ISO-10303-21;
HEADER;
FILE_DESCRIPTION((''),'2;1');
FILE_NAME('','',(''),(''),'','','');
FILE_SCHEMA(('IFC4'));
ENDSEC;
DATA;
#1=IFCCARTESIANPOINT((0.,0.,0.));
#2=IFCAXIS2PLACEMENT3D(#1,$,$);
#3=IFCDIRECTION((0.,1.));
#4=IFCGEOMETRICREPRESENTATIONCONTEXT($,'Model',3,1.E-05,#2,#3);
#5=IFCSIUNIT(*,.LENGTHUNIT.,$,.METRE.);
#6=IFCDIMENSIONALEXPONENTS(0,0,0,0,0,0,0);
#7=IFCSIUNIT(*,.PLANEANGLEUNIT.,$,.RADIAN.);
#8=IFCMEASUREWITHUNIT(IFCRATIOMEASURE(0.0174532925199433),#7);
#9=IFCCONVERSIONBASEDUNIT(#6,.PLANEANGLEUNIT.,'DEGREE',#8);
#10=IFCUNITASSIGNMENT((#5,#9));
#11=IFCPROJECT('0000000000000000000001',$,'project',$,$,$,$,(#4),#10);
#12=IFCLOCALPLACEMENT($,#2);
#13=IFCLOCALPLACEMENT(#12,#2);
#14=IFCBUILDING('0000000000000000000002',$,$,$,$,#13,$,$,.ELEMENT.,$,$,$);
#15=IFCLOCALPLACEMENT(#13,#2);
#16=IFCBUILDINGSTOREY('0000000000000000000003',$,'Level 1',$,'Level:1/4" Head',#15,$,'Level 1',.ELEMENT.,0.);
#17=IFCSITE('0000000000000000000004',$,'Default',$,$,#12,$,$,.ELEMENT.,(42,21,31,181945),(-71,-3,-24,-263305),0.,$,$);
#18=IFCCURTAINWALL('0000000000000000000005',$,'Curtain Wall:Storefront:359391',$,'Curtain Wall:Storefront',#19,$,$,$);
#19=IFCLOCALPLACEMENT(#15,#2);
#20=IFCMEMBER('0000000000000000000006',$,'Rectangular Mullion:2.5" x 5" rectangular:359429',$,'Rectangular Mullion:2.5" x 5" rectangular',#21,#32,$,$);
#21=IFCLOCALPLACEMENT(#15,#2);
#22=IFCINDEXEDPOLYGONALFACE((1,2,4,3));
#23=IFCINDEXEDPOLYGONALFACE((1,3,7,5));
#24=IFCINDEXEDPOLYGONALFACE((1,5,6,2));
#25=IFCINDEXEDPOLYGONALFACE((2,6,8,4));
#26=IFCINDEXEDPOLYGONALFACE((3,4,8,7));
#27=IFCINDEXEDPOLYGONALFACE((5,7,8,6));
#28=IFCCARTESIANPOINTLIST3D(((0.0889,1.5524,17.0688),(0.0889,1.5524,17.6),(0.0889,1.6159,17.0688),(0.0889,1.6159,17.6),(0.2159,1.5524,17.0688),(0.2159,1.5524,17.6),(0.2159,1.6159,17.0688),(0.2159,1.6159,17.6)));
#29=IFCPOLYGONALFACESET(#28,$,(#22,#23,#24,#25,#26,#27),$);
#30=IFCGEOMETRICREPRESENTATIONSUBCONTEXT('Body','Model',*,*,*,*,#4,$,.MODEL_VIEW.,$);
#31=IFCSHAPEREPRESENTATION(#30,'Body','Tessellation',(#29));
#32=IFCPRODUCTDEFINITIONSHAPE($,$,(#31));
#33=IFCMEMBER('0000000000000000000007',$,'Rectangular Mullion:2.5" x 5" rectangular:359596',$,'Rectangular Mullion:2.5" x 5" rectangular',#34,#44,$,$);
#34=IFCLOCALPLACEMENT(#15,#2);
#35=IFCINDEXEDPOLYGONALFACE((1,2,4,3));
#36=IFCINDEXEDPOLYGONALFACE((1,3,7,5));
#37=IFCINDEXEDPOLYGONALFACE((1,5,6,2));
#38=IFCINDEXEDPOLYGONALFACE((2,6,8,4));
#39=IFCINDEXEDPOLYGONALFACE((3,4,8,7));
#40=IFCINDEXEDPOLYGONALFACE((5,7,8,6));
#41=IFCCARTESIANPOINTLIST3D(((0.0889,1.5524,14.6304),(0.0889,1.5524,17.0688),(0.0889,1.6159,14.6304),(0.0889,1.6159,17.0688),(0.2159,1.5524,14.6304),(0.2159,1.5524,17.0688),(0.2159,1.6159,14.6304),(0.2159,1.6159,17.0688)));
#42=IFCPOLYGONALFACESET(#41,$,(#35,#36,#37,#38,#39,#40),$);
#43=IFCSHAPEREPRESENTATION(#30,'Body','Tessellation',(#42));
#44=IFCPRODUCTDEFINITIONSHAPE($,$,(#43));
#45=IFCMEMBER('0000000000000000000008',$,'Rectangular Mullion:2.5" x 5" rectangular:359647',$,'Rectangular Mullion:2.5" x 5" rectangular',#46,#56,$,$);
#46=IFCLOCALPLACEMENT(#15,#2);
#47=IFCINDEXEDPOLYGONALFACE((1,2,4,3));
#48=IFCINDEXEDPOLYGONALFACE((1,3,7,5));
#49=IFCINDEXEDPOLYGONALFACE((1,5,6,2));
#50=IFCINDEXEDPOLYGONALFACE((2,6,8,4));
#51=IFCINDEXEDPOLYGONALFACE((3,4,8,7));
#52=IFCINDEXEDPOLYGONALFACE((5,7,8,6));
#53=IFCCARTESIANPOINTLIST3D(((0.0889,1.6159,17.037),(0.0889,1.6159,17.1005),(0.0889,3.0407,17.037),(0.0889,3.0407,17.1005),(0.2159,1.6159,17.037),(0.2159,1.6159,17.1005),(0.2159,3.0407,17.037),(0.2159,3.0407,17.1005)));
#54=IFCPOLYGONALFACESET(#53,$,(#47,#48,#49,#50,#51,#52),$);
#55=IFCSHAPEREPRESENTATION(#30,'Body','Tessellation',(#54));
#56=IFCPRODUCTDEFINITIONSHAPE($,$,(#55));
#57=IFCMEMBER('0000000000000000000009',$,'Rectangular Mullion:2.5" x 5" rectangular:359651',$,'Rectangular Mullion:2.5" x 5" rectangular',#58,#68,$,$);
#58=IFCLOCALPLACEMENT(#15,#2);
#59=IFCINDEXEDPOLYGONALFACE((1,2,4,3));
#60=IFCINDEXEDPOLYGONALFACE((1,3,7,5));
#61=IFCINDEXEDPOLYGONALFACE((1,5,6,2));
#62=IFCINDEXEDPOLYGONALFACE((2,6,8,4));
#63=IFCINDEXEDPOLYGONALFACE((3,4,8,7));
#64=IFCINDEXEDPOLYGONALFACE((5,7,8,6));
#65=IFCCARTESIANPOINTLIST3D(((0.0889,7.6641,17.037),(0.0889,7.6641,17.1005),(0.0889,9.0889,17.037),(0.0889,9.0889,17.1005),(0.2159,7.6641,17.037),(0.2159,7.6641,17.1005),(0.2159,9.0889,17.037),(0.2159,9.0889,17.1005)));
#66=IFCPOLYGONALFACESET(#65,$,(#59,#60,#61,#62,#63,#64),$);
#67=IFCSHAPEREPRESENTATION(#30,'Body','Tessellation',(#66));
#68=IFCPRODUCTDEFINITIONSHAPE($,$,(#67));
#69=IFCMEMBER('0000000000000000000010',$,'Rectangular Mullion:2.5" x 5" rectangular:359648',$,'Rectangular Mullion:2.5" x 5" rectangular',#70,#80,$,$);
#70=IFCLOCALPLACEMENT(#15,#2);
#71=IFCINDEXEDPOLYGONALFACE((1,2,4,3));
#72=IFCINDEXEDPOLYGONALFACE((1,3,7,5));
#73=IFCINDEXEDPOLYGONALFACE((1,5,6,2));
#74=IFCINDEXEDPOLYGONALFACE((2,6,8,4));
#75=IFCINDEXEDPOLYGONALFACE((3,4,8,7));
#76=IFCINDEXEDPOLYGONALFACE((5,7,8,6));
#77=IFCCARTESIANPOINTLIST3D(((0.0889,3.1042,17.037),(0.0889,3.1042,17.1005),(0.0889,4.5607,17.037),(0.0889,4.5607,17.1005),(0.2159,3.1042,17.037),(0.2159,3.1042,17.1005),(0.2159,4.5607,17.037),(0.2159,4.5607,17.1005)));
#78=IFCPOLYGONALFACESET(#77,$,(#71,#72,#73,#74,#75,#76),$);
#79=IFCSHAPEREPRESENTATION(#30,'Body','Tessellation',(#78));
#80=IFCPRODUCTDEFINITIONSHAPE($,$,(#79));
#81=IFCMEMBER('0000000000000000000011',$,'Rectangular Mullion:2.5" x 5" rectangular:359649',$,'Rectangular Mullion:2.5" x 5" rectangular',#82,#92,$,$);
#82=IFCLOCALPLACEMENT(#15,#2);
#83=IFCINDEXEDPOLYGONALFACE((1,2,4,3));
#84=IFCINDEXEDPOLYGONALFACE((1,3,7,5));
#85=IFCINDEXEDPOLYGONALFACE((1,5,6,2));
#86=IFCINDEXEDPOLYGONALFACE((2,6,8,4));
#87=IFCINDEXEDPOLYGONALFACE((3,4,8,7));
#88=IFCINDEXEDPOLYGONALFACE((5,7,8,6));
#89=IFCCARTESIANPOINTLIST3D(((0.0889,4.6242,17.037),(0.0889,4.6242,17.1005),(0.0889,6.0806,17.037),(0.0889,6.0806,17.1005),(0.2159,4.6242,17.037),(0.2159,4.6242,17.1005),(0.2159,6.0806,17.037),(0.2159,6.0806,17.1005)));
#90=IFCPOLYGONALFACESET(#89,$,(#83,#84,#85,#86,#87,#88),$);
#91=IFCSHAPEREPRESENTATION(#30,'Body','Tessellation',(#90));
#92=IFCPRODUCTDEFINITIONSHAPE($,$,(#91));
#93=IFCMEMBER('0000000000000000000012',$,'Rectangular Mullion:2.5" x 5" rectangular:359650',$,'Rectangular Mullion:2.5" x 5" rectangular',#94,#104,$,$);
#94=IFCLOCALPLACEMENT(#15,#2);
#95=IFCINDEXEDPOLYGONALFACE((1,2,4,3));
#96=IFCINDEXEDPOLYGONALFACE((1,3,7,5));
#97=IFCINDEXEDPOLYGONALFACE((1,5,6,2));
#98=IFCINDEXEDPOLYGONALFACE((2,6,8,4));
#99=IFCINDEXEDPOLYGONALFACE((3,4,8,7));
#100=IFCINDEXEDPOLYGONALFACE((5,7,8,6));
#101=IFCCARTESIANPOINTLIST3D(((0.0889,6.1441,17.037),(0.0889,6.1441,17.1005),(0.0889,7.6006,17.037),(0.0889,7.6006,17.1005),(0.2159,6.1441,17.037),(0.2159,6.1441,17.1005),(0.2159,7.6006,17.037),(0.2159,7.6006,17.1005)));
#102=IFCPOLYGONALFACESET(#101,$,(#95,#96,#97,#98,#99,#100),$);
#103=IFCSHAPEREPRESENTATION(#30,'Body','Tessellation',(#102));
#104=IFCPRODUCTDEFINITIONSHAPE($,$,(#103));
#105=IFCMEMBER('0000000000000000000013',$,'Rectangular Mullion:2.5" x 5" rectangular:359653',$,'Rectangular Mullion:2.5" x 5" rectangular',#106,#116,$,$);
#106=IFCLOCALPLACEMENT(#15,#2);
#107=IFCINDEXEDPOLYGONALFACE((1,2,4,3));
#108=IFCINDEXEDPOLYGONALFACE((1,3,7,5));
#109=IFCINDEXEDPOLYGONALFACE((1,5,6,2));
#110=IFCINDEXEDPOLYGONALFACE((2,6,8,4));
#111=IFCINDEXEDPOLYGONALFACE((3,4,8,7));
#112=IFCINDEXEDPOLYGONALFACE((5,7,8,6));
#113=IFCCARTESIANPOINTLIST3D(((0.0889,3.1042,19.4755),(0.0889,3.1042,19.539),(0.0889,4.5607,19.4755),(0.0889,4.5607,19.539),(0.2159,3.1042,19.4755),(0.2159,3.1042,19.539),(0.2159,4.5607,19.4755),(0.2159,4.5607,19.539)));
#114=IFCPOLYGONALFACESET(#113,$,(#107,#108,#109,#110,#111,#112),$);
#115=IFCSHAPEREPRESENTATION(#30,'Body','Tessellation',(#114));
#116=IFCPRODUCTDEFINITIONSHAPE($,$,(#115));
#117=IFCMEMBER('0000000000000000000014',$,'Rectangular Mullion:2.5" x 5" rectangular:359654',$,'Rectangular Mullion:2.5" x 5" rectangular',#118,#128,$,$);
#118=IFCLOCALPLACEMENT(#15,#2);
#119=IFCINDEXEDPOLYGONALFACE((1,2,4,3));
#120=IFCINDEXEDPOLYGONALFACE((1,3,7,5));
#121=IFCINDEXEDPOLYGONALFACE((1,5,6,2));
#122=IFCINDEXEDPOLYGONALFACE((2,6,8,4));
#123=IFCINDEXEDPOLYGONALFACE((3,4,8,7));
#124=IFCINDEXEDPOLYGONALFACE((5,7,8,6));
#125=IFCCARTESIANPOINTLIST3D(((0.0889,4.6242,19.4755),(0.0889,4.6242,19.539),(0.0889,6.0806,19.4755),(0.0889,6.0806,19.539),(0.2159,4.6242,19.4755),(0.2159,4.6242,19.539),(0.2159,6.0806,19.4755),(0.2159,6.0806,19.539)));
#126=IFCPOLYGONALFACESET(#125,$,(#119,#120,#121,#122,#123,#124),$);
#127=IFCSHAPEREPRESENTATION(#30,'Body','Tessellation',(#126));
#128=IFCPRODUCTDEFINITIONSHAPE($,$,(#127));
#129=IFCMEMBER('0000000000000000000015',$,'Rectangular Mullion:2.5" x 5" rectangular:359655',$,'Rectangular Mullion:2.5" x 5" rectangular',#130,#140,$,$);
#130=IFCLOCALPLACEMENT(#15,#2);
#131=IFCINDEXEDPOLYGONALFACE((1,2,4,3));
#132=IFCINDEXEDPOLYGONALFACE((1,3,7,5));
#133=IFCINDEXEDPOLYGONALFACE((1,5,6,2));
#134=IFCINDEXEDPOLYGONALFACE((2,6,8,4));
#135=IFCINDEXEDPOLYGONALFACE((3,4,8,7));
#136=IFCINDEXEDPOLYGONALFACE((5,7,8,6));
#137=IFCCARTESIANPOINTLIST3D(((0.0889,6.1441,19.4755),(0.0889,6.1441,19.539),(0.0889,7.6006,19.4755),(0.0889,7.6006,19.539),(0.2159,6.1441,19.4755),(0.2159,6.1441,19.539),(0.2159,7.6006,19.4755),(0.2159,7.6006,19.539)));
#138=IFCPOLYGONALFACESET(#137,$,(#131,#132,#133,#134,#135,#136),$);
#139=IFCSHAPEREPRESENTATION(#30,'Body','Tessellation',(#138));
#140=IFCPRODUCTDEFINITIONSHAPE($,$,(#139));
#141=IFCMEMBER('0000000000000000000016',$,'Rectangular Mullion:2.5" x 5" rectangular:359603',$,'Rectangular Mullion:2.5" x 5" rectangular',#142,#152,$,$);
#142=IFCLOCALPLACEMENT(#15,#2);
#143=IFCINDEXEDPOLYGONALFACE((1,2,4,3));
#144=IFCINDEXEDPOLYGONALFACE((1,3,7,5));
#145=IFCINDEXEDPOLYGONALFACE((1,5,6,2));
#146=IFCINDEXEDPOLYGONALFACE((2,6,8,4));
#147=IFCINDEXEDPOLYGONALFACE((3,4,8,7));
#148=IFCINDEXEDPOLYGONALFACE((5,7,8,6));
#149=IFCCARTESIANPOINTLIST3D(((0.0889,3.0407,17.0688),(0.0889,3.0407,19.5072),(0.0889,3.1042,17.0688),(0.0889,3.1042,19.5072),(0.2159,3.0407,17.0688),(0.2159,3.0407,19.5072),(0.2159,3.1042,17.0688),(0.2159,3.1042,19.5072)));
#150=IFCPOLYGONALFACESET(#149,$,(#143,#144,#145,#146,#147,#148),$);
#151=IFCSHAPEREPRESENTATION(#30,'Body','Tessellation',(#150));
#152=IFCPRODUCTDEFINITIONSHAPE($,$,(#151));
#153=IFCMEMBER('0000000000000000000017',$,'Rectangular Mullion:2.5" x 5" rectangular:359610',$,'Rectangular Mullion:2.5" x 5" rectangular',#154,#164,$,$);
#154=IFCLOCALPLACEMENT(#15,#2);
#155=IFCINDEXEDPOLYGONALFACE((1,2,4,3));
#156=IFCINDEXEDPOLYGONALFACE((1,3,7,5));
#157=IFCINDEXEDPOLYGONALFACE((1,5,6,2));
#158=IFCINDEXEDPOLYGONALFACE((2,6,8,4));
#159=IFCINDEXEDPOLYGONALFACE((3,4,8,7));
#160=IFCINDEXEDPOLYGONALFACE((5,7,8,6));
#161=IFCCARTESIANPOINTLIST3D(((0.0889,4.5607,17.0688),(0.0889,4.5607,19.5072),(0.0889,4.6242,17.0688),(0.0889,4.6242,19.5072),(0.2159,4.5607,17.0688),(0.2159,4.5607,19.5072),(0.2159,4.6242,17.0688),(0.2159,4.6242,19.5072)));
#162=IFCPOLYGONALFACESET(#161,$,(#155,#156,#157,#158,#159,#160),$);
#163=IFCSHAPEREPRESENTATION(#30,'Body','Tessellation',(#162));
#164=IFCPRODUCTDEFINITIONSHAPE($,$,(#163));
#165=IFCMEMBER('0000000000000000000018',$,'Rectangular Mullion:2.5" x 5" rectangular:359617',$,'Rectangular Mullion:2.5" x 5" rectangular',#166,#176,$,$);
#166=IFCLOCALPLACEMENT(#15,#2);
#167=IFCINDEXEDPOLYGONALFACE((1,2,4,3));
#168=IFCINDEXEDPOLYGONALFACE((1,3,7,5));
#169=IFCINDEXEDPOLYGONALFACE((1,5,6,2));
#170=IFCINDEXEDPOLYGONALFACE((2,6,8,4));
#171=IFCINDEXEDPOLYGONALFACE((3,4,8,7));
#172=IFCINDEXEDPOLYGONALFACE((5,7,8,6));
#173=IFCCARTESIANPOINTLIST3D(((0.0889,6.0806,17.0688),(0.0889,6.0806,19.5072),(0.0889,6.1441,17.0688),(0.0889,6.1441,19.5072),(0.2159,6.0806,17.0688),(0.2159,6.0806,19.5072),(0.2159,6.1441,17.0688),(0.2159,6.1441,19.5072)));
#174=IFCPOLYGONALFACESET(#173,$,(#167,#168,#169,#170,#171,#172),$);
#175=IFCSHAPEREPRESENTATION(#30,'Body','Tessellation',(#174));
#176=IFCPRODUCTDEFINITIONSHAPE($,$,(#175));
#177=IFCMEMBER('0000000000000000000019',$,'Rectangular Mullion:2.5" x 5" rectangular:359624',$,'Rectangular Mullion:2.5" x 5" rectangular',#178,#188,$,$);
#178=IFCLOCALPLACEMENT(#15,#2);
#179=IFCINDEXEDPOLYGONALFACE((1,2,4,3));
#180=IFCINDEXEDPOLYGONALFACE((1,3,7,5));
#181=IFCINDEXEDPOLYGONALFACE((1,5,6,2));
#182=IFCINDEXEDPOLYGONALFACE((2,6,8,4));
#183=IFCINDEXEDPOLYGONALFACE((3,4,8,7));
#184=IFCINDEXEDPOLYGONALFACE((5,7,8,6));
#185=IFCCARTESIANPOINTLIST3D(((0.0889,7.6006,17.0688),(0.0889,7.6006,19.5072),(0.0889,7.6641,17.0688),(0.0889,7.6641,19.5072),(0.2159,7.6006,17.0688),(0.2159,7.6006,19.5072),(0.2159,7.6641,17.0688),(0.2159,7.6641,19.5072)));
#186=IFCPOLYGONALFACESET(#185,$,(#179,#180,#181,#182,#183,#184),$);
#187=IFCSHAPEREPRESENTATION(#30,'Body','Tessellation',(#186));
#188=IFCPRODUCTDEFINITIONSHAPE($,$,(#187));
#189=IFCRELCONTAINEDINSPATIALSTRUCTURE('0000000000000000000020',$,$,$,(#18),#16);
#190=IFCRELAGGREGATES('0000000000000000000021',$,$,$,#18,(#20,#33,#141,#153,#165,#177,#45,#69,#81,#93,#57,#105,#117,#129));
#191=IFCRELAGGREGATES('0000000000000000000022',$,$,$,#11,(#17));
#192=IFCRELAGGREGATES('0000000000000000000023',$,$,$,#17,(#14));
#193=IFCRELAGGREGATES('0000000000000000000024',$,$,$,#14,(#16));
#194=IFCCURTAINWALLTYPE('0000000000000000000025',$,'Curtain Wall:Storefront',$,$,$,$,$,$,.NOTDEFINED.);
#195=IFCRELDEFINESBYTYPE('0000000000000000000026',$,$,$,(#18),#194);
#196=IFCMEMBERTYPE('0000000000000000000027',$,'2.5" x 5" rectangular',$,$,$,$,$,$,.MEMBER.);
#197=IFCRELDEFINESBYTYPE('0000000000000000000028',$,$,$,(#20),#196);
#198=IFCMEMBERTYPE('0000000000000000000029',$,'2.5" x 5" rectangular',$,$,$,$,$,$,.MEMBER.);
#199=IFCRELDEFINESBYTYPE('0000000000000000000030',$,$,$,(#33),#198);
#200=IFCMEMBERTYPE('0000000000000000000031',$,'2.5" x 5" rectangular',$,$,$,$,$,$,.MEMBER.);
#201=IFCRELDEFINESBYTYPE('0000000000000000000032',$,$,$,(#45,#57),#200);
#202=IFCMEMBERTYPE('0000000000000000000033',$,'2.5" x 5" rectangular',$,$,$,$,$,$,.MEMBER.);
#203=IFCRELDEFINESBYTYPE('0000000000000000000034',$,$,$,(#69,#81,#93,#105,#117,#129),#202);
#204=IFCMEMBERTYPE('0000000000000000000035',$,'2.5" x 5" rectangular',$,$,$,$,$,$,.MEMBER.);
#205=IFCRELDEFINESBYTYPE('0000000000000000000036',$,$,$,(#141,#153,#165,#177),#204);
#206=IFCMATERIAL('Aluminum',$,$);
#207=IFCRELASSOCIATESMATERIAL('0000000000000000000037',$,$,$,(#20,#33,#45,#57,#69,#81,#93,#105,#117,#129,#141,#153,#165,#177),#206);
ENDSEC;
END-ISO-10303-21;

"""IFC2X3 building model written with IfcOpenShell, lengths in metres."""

from ifc_helpers import new_model, entity, si_unit, converted_unit, direction, frame, origin, origin_2d_with_axis, place, context, subcontext, project, spatial, rectangle, extrude, source, transform, mapped, material, type_object, type_shapes, element, aggregate, save


model = new_model("IFC2X3")

# Units and contexts
model_context = context("Model", 3, precision=1e-05, world=origin(), true_north=direction((0.0, 1.0)))
body_context = subcontext(model_context, "Body", "Model", "MODEL_VIEW")
ifc_project = project(units=[si_unit("LENGTHUNIT", "METRE"), converted_unit("PLANEANGLEUNIT", "DEGREE", entity("IfcRatioMeasure", 0.0174532925199433), si_unit("PLANEANGLEUNIT", "RADIAN"), dimensions=[0, 0, 0, 0, 0, 0, 0])], contexts=[model_context])

# Site, building, storey
site_placement = place(None, origin())
site = spatial("IfcSite", under=ifc_project, at=site_placement, Name="Default", CompositionType="ELEMENT", RefLatitude=(42, 21, 31, 181945), RefLongitude=(-71, -3, -24, -263305), RefElevation=0.0)
building_placement = place(site_placement, origin())
building = spatial("IfcBuilding", under=site, at=building_placement, CompositionType="ELEMENT")
storey_placement = place(building_placement, origin())
storey = spatial("IfcBuildingStorey", under=building, at=storey_placement, Name="Level 1", ObjectType="Level:1/4\" Head", LongName="Level 1", CompositionType="ELEMENT", Elevation=0.0)

# Curtain wall, members
curtain_wall_type = type_object("IfcCurtainWallType", Name="Curtain Wall:Storefront", PredefinedType="NOTDEFINED")
curtain_wall_1_placement = place(storey_placement, origin())
curtain_wall_1 = element("IfcCurtainWall", 1, at=curtain_wall_1_placement, inside=storey, type_object=curtain_wall_type, Name="Curtain Wall:Storefront:359391", ObjectType="Curtain Wall:Storefront")
ifc_material_1 = material(Name="Aluminum")
member_type_1 = type_object("IfcMemberType", Name="2.5\" x 5\" rectangular", PredefinedType="MEMBER")
shared_shape_1 = source(origin(), body_context, "Body", "SweptSolid", [
    extrude(rectangle(XDim=0.127, YDim=0.0635, at=origin_2d_with_axis()), frame((-0.0318, 0.0, -0.5312), z_axis=(0.0, 0.0, 1.0), x_axis=(0.0, -1.0, 0.0)), (0.0, 0.0, 1.0), 0.5312),
])
type_shapes(member_type_1, [shared_shape_1])
member_1_placement = place(storey_placement, frame((0.1524, 1.5524, 17.6), z_axis=(0.0, 0.0, 1.0), x_axis=(0.0, -1.0, 0.0)))
member_1 = element("IfcMember", 2, at=member_1_placement, type_object=member_type_1, material=ifc_material_1, Name="Rectangular Mullion:2.5\" x 5\" rectangular:359429", ObjectType="Rectangular Mullion:2.5\" x 5\" rectangular", context=body_context, shape_type="MappedRepresentation", body=[
    mapped(shared_shape_1, transform((0.0, 0.0, 0.0), scale=1.0)),
])
member_type_2 = type_object("IfcMemberType", Name="2.5\" x 5\" rectangular", PredefinedType="MEMBER")
shared_shape_2 = source(origin(), body_context, "Body", "SweptSolid", [
    extrude(rectangle(XDim=0.127, YDim=0.0635, at=origin_2d_with_axis()), frame((-0.0318, 0.0, -2.4384), z_axis=(0.0, 0.0, 1.0), x_axis=(0.0, -1.0, 0.0)), (0.0, 0.0, 1.0), 2.4384),
])
type_shapes(member_type_2, [shared_shape_2])
member_2_placement = place(storey_placement, frame((0.1524, 1.5524, 17.0688), z_axis=(0.0, 0.0, 1.0), x_axis=(0.0, -1.0, 0.0)))
member_2 = element("IfcMember", 3, at=member_2_placement, type_object=member_type_2, material=ifc_material_1, Name="Rectangular Mullion:2.5\" x 5\" rectangular:359596", ObjectType="Rectangular Mullion:2.5\" x 5\" rectangular", context=body_context, shape_type="MappedRepresentation", body=[
    mapped(shared_shape_2, transform((0.0, 0.0, 0.0), scale=1.0)),
])
member_type_3 = type_object("IfcMemberType", Name="2.5\" x 5\" rectangular", PredefinedType="MEMBER")
shared_shape_3 = source(origin(), body_context, "Body", "SweptSolid", [
    extrude(rectangle(XDim=0.127, YDim=0.0635, at=origin_2d_with_axis()), frame((0.0, 0.0, -1.4248), z_axis=(0.0, 0.0, 1.0), x_axis=(0.0, -1.0, 0.0)), (0.0, 0.0, 1.0), 1.4248),
])
type_shapes(member_type_3, [shared_shape_3])
member_3_placement = place(storey_placement, frame((0.1524, 3.0407, 17.0688), z_axis=(0.0, 1.0, 0.0), x_axis=(0.0, 0.0, 1.0)))
member_3 = element("IfcMember", 4, at=member_3_placement, type_object=member_type_3, material=ifc_material_1, Name="Rectangular Mullion:2.5\" x 5\" rectangular:359647", ObjectType="Rectangular Mullion:2.5\" x 5\" rectangular", context=body_context, shape_type="MappedRepresentation", body=[
    mapped(shared_shape_3, transform((0.0, 0.0, 0.0), scale=1.0)),
])
member_4_placement = place(storey_placement, frame((0.1524, 9.0889, 17.0688), z_axis=(0.0, 1.0, 0.0), x_axis=(0.0, 0.0, 1.0)))
member_4 = element("IfcMember", 5, at=member_4_placement, type_object=member_type_3, material=ifc_material_1, Name="Rectangular Mullion:2.5\" x 5\" rectangular:359651", ObjectType="Rectangular Mullion:2.5\" x 5\" rectangular", context=body_context, shape_type="MappedRepresentation", body=[
    mapped(shared_shape_3, transform((0.0, 0.0, 0.0), scale=1.0)),
])
member_type_4 = type_object("IfcMemberType", Name="2.5\" x 5\" rectangular", PredefinedType="MEMBER")
shared_shape_4 = source(origin(), body_context, "Body", "SweptSolid", [
    extrude(rectangle(XDim=0.127, YDim=0.0635, at=origin_2d_with_axis()), frame((0.0, 0.0, -1.4565), z_axis=(0.0, 0.0, 1.0), x_axis=(0.0, -1.0, 0.0)), (0.0, 0.0, 1.0), 1.4565),
])
type_shapes(member_type_4, [shared_shape_4])
member_5_placement = place(storey_placement, frame((0.1524, 4.5607, 17.0688), z_axis=(0.0, 1.0, 0.0), x_axis=(0.0, 0.0, 1.0)))
member_5 = element("IfcMember", 6, at=member_5_placement, type_object=member_type_4, material=ifc_material_1, Name="Rectangular Mullion:2.5\" x 5\" rectangular:359648", ObjectType="Rectangular Mullion:2.5\" x 5\" rectangular", context=body_context, shape_type="MappedRepresentation", body=[
    mapped(shared_shape_4, transform((0.0, 0.0, 0.0), scale=1.0)),
])
member_6_placement = place(storey_placement, frame((0.1524, 6.0806, 17.0688), z_axis=(0.0, 1.0, 0.0), x_axis=(0.0, 0.0, 1.0)))
member_6 = element("IfcMember", 7, at=member_6_placement, type_object=member_type_4, material=ifc_material_1, Name="Rectangular Mullion:2.5\" x 5\" rectangular:359649", ObjectType="Rectangular Mullion:2.5\" x 5\" rectangular", context=body_context, shape_type="MappedRepresentation", body=[
    mapped(shared_shape_4, transform((0.0, 0.0, 0.0), scale=1.0)),
])
member_7_placement = place(storey_placement, frame((0.1524, 7.6006, 17.0688), z_axis=(0.0, 1.0, 0.0), x_axis=(0.0, 0.0, 1.0)))
member_7 = element("IfcMember", 8, at=member_7_placement, type_object=member_type_4, material=ifc_material_1, Name="Rectangular Mullion:2.5\" x 5\" rectangular:359650", ObjectType="Rectangular Mullion:2.5\" x 5\" rectangular", context=body_context, shape_type="MappedRepresentation", body=[
    mapped(shared_shape_4, transform((0.0, 0.0, 0.0), scale=1.0)),
])
member_8_placement = place(storey_placement, frame((0.1524, 4.5607, 19.5072), z_axis=(0.0, 1.0, 0.0), x_axis=(0.0, 0.0, 1.0)))
member_8 = element("IfcMember", 9, at=member_8_placement, type_object=member_type_4, material=ifc_material_1, Name="Rectangular Mullion:2.5\" x 5\" rectangular:359653", ObjectType="Rectangular Mullion:2.5\" x 5\" rectangular", context=body_context, shape_type="MappedRepresentation", body=[
    mapped(shared_shape_4, transform((0.0, 0.0, 0.0), scale=1.0)),
])
member_9_placement = place(storey_placement, frame((0.1524, 6.0806, 19.5072), z_axis=(0.0, 1.0, 0.0), x_axis=(0.0, 0.0, 1.0)))
member_9 = element("IfcMember", 10, at=member_9_placement, type_object=member_type_4, material=ifc_material_1, Name="Rectangular Mullion:2.5\" x 5\" rectangular:359654", ObjectType="Rectangular Mullion:2.5\" x 5\" rectangular", context=body_context, shape_type="MappedRepresentation", body=[
    mapped(shared_shape_4, transform((0.0, 0.0, 0.0), scale=1.0)),
])
member_10_placement = place(storey_placement, frame((0.1524, 7.6006, 19.5072), z_axis=(0.0, 1.0, 0.0), x_axis=(0.0, 0.0, 1.0)))
member_10 = element("IfcMember", 11, at=member_10_placement, type_object=member_type_4, material=ifc_material_1, Name="Rectangular Mullion:2.5\" x 5\" rectangular:359655", ObjectType="Rectangular Mullion:2.5\" x 5\" rectangular", context=body_context, shape_type="MappedRepresentation", body=[
    mapped(shared_shape_4, transform((0.0, 0.0, 0.0), scale=1.0)),
])
member_type_5 = type_object("IfcMemberType", Name="2.5\" x 5\" rectangular", PredefinedType="MEMBER")
shared_shape_5 = source(origin(), body_context, "Body", "SweptSolid", [
    extrude(rectangle(XDim=0.127, YDim=0.0635, at=origin_2d_with_axis()), frame((0.0, 0.0, -2.4384), z_axis=(0.0, 0.0, 1.0), x_axis=(0.0, -1.0, 0.0)), (0.0, 0.0, 1.0), 2.4384),
])
type_shapes(member_type_5, [shared_shape_5])
member_11_placement = place(storey_placement, frame((0.1524, 3.0724, 17.0688), z_axis=(0.0, 0.0, -1.0), x_axis=(0.0, 1.0, 0.0)))
member_11 = element("IfcMember", 12, at=member_11_placement, type_object=member_type_5, material=ifc_material_1, Name="Rectangular Mullion:2.5\" x 5\" rectangular:359603", ObjectType="Rectangular Mullion:2.5\" x 5\" rectangular", context=body_context, shape_type="MappedRepresentation", body=[
    mapped(shared_shape_5, transform((0.0, 0.0, 0.0), scale=1.0)),
])
member_12_placement = place(storey_placement, frame((0.1524, 4.5924, 17.0688), z_axis=(0.0, 0.0, -1.0), x_axis=(0.0, 1.0, 0.0)))
member_12 = element("IfcMember", 13, at=member_12_placement, type_object=member_type_5, material=ifc_material_1, Name="Rectangular Mullion:2.5\" x 5\" rectangular:359610", ObjectType="Rectangular Mullion:2.5\" x 5\" rectangular", context=body_context, shape_type="MappedRepresentation", body=[
    mapped(shared_shape_5, transform((0.0, 0.0, 0.0), scale=1.0)),
])
member_13_placement = place(storey_placement, frame((0.1524, 6.1124, 17.0688), z_axis=(0.0, 0.0, -1.0), x_axis=(0.0, 1.0, 0.0)))
member_13 = element("IfcMember", 14, at=member_13_placement, type_object=member_type_5, material=ifc_material_1, Name="Rectangular Mullion:2.5\" x 5\" rectangular:359617", ObjectType="Rectangular Mullion:2.5\" x 5\" rectangular", context=body_context, shape_type="MappedRepresentation", body=[
    mapped(shared_shape_5, transform((0.0, 0.0, 0.0), scale=1.0)),
])
member_14_placement = place(storey_placement, frame((0.1524, 7.6324, 17.0688), z_axis=(0.0, 0.0, -1.0), x_axis=(0.0, 1.0, 0.0)))
member_14 = element("IfcMember", 15, at=member_14_placement, type_object=member_type_5, material=ifc_material_1, Name="Rectangular Mullion:2.5\" x 5\" rectangular:359624", ObjectType="Rectangular Mullion:2.5\" x 5\" rectangular", context=body_context, shape_type="MappedRepresentation", body=[
    mapped(shared_shape_5, transform((0.0, 0.0, 0.0), scale=1.0)),
])

aggregate(curtain_wall_1, [member_1, member_2, member_11, member_12, member_13, member_14, member_3, member_5, member_6, member_7, member_4, member_8, member_9, member_10])

save(model, "model.ifc")
